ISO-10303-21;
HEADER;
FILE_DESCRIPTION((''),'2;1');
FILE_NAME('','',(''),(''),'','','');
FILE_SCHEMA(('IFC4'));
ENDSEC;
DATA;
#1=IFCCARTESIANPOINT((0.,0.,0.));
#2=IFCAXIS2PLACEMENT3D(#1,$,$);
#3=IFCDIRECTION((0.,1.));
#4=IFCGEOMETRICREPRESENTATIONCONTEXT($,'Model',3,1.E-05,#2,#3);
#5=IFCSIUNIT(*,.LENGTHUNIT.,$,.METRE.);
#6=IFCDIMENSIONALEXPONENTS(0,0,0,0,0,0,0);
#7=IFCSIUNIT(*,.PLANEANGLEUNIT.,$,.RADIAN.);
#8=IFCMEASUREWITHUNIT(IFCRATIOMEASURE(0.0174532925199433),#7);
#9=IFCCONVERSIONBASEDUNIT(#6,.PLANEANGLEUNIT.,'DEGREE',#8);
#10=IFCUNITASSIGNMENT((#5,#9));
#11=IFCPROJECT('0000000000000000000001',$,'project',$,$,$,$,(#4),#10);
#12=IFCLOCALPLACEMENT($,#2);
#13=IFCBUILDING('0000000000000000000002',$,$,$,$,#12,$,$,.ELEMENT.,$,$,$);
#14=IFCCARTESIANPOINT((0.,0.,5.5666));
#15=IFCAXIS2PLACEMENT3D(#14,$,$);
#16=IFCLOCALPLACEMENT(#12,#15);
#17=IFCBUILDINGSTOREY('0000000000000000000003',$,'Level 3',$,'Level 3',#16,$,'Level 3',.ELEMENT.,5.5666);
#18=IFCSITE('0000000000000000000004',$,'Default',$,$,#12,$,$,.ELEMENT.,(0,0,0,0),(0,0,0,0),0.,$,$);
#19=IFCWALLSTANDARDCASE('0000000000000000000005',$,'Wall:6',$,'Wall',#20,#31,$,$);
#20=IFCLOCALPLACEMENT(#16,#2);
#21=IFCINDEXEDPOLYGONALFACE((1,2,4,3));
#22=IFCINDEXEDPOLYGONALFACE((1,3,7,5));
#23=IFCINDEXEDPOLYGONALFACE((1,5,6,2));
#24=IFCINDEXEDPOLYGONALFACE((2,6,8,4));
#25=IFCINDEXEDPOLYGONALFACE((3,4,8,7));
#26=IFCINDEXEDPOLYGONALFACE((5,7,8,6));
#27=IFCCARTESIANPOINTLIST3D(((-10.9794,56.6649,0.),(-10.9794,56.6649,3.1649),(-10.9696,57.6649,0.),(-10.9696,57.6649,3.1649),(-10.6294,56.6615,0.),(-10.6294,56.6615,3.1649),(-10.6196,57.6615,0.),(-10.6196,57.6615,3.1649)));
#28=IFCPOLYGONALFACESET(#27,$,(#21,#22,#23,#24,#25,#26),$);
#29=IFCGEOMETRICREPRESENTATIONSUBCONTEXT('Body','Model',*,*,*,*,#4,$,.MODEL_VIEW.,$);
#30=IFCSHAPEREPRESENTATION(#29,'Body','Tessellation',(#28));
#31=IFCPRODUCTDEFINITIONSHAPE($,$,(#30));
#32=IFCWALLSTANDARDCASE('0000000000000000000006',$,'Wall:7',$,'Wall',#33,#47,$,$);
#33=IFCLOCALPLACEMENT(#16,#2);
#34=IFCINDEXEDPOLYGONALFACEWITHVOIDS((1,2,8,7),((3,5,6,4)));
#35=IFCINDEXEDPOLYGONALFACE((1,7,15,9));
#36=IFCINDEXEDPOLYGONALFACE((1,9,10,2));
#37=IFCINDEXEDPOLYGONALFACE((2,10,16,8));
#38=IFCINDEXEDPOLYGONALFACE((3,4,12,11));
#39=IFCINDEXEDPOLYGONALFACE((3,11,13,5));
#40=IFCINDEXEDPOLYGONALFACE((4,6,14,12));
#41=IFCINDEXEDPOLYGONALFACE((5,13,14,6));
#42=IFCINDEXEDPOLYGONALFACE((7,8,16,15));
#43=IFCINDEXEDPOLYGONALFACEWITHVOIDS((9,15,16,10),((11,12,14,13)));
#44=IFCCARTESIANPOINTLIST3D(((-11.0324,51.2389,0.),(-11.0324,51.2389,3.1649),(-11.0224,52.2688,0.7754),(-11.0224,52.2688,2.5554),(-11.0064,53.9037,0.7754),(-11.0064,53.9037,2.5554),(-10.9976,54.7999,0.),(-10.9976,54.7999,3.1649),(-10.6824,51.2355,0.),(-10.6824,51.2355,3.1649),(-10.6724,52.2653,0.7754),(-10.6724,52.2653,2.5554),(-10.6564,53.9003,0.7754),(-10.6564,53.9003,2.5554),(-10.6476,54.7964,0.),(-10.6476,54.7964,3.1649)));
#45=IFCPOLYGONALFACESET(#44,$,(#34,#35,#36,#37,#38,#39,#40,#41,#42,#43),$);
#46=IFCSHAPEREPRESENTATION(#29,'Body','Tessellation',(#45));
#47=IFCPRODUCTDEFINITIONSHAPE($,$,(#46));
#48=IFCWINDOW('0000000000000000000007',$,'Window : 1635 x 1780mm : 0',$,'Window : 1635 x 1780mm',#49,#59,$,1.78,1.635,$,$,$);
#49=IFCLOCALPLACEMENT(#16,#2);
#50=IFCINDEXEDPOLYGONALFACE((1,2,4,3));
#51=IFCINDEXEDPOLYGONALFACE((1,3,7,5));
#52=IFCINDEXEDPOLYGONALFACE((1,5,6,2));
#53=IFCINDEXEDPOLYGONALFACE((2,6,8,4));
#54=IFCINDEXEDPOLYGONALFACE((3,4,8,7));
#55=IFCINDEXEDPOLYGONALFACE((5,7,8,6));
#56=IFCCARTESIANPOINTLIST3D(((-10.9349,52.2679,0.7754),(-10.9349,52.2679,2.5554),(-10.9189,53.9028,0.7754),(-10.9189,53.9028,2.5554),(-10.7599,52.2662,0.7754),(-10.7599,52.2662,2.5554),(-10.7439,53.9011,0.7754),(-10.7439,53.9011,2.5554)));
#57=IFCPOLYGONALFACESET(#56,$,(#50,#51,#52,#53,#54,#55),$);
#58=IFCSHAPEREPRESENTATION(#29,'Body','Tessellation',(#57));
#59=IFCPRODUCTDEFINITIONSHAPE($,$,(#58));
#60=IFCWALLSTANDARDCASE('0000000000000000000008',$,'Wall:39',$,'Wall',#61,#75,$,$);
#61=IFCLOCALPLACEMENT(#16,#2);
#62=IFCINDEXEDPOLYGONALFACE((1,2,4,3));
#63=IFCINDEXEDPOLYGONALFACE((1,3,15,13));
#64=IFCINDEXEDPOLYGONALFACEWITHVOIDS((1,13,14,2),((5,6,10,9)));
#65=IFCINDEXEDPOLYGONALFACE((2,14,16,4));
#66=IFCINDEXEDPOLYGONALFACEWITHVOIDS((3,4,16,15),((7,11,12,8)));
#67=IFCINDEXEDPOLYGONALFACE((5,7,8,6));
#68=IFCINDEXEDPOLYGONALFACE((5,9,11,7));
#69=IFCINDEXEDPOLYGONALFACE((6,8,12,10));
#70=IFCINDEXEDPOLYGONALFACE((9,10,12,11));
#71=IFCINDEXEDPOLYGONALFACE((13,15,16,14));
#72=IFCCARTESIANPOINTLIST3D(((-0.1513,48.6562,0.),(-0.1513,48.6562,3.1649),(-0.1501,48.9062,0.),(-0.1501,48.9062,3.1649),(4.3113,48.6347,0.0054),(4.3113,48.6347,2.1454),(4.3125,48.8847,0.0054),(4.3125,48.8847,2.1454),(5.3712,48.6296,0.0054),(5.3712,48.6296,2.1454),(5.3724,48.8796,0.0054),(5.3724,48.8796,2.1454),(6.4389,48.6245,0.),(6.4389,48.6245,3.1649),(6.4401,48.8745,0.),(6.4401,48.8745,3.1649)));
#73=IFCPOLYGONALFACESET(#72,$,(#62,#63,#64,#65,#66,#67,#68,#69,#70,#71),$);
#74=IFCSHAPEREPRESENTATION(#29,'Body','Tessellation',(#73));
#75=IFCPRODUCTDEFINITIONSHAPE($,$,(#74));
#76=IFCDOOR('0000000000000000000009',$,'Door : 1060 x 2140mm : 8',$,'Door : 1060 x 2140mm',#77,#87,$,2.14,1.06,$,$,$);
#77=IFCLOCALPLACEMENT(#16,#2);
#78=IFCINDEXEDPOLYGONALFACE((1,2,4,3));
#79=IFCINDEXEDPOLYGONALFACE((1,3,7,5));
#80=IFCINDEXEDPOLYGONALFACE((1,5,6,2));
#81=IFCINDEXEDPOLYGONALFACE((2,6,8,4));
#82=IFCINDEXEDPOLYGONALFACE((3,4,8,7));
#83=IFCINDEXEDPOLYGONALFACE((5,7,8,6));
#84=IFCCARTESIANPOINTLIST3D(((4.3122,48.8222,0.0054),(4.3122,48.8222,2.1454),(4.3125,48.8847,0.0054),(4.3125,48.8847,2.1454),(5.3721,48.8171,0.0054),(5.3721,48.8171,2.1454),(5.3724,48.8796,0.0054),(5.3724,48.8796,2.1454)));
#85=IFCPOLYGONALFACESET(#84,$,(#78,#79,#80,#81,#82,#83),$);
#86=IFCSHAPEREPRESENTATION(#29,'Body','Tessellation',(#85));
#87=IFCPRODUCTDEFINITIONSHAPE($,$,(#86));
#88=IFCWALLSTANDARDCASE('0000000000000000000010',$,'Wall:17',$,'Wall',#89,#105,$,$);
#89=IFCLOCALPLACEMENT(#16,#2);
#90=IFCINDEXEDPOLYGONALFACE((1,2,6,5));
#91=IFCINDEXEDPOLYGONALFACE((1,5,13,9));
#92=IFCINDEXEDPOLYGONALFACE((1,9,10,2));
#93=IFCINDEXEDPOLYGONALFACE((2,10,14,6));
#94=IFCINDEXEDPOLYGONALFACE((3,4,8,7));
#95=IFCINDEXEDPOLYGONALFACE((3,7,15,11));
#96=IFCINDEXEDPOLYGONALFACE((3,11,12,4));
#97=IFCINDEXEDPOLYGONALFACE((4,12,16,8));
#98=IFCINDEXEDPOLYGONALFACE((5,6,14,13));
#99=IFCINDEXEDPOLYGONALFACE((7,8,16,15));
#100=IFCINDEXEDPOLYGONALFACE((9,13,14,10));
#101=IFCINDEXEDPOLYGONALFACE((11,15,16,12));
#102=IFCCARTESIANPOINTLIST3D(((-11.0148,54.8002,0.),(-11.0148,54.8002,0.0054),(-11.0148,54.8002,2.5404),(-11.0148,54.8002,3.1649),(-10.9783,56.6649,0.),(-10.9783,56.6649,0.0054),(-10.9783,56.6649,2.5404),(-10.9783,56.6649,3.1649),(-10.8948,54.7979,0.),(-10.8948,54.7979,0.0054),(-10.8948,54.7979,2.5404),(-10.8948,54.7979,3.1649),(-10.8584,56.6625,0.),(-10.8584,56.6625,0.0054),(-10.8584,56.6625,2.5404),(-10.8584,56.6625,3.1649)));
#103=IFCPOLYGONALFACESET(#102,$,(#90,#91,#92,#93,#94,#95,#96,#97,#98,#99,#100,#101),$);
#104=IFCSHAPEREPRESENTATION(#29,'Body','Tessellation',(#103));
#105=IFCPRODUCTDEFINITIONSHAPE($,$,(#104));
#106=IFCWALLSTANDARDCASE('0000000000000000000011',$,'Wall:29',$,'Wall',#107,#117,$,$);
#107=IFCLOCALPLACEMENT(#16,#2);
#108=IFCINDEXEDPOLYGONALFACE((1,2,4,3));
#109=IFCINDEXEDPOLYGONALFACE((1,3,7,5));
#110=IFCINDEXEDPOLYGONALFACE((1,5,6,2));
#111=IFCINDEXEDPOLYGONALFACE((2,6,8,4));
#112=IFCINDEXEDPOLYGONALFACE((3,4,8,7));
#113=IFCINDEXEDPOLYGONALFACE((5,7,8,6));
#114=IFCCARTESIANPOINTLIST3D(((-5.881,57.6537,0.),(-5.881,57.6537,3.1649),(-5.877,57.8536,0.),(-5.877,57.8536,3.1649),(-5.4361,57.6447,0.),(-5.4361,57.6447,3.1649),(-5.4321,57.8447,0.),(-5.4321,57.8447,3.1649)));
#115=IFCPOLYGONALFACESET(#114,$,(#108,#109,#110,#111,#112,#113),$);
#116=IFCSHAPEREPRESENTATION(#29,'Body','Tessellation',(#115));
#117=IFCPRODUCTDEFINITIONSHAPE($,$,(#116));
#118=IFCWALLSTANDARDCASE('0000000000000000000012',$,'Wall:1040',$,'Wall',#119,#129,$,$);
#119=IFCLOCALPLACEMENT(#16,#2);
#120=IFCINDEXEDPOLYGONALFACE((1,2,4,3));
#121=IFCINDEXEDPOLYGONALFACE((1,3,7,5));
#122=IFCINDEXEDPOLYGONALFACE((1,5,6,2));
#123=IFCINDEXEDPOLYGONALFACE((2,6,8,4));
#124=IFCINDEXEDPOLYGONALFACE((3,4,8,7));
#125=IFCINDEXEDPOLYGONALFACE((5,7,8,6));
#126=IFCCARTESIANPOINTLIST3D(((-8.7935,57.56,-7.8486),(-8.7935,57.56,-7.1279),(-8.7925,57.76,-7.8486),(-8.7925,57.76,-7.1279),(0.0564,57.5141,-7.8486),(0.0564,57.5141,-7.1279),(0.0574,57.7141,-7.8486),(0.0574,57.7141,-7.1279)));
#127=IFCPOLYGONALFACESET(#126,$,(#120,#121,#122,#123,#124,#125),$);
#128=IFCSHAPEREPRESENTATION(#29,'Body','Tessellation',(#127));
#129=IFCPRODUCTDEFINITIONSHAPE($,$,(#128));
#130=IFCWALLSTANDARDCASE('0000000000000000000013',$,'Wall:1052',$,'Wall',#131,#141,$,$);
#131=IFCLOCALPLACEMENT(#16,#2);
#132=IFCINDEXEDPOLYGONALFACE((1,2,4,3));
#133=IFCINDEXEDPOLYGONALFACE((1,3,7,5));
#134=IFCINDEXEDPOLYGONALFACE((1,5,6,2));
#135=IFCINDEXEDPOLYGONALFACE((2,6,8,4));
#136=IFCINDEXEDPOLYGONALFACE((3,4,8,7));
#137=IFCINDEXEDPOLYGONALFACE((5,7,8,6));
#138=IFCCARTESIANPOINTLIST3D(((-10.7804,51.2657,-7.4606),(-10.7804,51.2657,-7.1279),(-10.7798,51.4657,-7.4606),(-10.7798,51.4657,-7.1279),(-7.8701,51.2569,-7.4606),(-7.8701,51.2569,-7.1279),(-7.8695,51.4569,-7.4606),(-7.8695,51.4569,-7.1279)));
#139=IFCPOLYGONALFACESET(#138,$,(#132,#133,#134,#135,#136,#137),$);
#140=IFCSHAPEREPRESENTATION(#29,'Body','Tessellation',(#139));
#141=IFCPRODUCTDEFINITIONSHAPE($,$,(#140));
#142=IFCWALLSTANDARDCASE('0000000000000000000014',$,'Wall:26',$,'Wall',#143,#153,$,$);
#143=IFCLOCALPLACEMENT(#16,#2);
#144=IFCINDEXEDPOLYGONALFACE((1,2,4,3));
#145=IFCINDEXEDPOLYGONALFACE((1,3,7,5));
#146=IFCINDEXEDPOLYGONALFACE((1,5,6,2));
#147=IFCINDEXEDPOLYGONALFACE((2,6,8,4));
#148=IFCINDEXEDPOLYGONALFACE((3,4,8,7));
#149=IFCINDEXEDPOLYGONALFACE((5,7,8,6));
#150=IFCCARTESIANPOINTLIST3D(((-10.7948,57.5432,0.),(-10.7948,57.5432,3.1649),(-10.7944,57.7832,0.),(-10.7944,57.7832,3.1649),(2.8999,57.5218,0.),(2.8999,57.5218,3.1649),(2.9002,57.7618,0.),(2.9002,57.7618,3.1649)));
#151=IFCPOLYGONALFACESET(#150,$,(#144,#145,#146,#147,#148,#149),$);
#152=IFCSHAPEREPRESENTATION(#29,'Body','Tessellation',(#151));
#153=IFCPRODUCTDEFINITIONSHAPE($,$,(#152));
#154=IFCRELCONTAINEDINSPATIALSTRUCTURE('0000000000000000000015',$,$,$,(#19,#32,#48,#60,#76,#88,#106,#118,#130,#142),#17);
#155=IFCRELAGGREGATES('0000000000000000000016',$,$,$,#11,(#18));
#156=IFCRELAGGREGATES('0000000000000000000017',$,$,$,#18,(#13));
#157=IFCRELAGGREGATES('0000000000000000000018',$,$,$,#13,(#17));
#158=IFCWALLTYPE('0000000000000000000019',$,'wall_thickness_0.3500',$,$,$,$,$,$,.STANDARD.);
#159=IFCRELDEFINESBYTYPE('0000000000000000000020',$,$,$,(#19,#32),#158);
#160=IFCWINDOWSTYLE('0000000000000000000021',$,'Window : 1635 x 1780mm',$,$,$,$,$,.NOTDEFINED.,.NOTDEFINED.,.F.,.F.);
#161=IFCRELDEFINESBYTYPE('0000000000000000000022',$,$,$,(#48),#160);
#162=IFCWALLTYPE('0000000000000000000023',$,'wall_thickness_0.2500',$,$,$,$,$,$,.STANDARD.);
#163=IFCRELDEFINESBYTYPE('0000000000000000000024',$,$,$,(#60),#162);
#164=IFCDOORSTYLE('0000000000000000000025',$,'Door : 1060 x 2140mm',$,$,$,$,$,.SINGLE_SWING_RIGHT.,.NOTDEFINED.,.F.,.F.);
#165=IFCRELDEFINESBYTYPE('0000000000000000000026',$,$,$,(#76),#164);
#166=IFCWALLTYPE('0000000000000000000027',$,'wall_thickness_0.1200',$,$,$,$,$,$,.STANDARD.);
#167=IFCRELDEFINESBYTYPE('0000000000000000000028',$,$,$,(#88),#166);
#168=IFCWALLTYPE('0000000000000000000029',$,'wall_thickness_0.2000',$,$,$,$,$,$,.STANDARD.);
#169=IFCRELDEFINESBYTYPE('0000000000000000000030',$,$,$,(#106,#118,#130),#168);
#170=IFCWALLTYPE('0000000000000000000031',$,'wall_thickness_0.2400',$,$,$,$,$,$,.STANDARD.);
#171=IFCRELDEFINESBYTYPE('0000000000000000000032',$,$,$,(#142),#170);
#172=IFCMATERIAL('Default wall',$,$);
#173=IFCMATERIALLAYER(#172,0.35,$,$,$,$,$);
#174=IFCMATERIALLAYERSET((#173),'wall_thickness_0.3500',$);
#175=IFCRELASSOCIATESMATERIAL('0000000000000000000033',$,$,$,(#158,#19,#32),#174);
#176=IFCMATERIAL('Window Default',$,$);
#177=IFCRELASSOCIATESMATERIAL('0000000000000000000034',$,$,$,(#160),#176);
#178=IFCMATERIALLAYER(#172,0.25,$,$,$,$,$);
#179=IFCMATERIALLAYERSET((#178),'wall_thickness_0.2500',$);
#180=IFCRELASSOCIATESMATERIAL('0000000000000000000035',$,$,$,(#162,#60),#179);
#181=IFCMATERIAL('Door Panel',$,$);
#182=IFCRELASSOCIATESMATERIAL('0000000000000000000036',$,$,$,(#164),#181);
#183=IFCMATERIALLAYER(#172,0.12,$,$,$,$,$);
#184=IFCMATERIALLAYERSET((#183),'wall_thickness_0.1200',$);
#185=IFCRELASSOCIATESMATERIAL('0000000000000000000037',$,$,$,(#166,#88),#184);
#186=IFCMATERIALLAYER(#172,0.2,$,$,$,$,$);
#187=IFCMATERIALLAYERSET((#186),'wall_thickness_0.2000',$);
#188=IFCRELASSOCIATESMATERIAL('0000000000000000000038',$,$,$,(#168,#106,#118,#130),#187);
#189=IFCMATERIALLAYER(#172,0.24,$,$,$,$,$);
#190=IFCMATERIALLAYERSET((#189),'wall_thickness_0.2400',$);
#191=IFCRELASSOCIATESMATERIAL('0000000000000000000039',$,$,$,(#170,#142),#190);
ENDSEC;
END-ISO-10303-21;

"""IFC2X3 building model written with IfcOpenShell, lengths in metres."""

from ifc_helpers import new_model, entity, si_unit, converted_unit, direction, frame, frame_2d, origin, origin_2d_with_axis, place, context, subcontext, project, spatial, polyline, rectangle, outline, extrude, source, transform, mapped, material, layer, layer_set, layer_usage, type_object, type_shapes, element, fill, save


model = new_model("IFC2X3")

# Units and contexts
model_context = context("Model", 3, precision=1e-05, world=origin(), true_north=direction((0.0, 1.0)))
body_context = subcontext(model_context, "Body", "Model", "MODEL_VIEW")
ifc_project = project(units=[si_unit("LENGTHUNIT", "METRE"), converted_unit("PLANEANGLEUNIT", "DEGREE", entity("IfcRatioMeasure", 0.0174532925199433), si_unit("PLANEANGLEUNIT", "RADIAN"), dimensions=[0, 0, 0, 0, 0, 0, 0])], contexts=[model_context])

# Site, building, storey
placement_1 = place(None, origin())
site = spatial("IfcSite", under=ifc_project, at=placement_1, Name="Default", CompositionType="ELEMENT", RefLatitude=(0, 0, 0, 0), RefLongitude=(0, 0, 0, 0), RefElevation=0.0)
building = spatial("IfcBuilding", under=site, at=placement_1, CompositionType="ELEMENT")
storey_placement = place(placement_1, frame((0.0, 0.0, 5.5666)))
storey = spatial("IfcBuildingStorey", under=building, at=storey_placement, Name="Level 3", ObjectType="Level 3", LongName="Level 3", CompositionType="ELEMENT", Elevation=5.5666)

# Wall
ifc_material_1 = material(Name="Default wall")
ifc_layer_1 = layer(ifc_material_1, 0.35)
ifc_layer_set_1 = layer_set([ifc_layer_1], Name="wall_thickness_0.3500")
ifc_layer_usage_1 = layer_usage(ifc_layer_set_1, "AXIS2", "POSITIVE", -0.175)
wall_type_1 = type_object("IfcWallType", Name="wall_thickness_0.3500", PredefinedType="STANDARD", material=ifc_layer_set_1)
wall_1_placement = place(storey_placement, frame((-10.7946, 57.6632, 0.0), z_axis=(0.0, 0.0, 1.0), x_axis=(-0.009774, -0.999952, 0.0)))
element("IfcWallStandardCase", 1, at=wall_1_placement, inside=storey, type_object=wall_type_1, material=ifc_layer_usage_1, Name="Wall:6", ObjectType="Wall", context=body_context, shape_type="SweptSolid", body=[
    extrude(outline(polyline([(1.0001, -0.175), (1.0001, 0.175), (0.0, 0.175), (0.0, -0.175), (1.0001, -0.175)])), origin(), (0.0, 0.0, 1.0), 3.1649),
])

# Wall, opening, window
wall_2_placement = place(storey_placement, frame((-10.8226, 54.7982, 0.0), z_axis=(0.0, 0.0, 1.0), x_axis=(-0.009774, -0.999952, 0.0)))
wall_2 = element("IfcWallStandardCase", 2, at=wall_2_placement, inside=storey, type_object=wall_type_1, material=ifc_layer_usage_1, Name="Wall:7", ObjectType="Wall", context=body_context, shape_type="SweptSolid", body=[
    extrude(outline(polyline([(3.5612, -0.175), (3.5612, 0.175), (0.0, 0.175), (0.0, -0.175), (3.5612, -0.175)])), origin(), (0.0, 0.0, 1.0), 3.1649),
])
opening_1_placement = place(wall_2_placement, frame((0.8962, -0.175, 0.7754)))
opening_1 = element("IfcOpeningElement", 3, at=opening_1_placement, cuts=wall_2, ObjectType="Opening", context=body_context, shape_type="SweptSolid", body=[
    extrude(rectangle(XDim=1.635, YDim=1.78, at=frame_2d((0.89, 0.8175), x_axis=(0.0, 1.0))), frame((0.0, 0.0, 0.0), z_axis=(0.0, 1.0, 0.0), x_axis=(0.0, 0.0, 1.0)), (0.0, 0.0, 1.0), 0.35),
])
ifc_material_2 = material(Name="Window Default")
window_style_1 = type_object("IfcWindowStyle", Name="Window : 1635 x 1780mm", ConstructionType="NOTDEFINED", OperationType="NOTDEFINED", ParameterTakesPrecedence=False, Sizeable=False, material=ifc_material_2)
shared_shape_1 = source(origin(), body_context, "Body", "SweptSolid", [
    extrude(rectangle(XDim=0.175, YDim=1.635, at=origin_2d_with_axis()), frame((0.8175, 0.175, 0.0), z_axis=(0.0, 0.0, 1.0), x_axis=(0.0, 1.0, 0.0)), (0.0, 0.0, 1.0), 1.78),
])
type_shapes(window_style_1, [shared_shape_1])
window_1_placement = place(opening_1_placement, origin())
window_1 = element("IfcWindow", 4, at=window_1_placement, inside=storey, type_object=window_style_1, Name="Window : 1635 x 1780mm : 0", ObjectType="Window : 1635 x 1780mm", OverallHeight=1.78, OverallWidth=1.635, context=body_context, shape_type="MappedRepresentation", body=[
    mapped(shared_shape_1, transform((0.0, 0.0, 0.0), scale=1.0)),
])
fill(opening_1, window_1)

# Wall, opening, door
ifc_layer_2 = layer(ifc_material_1, 0.25)
ifc_layer_set_2 = layer_set([ifc_layer_2], Name="wall_thickness_0.2500")
ifc_layer_usage_2 = layer_usage(ifc_layer_set_2, "AXIS2", "POSITIVE", -0.125)
wall_type_2 = type_object("IfcWallType", Name="wall_thickness_0.2500", PredefinedType="STANDARD", material=ifc_layer_set_2)
wall_3_placement = place(storey_placement, frame((-0.1507, 48.7812, 0.0), z_axis=(0.0, 0.0, 1.0), x_axis=(0.999988, -0.004812, 0.0)))
wall_3 = element("IfcWallStandardCase", 5, at=wall_3_placement, inside=storey, type_object=wall_type_2, material=ifc_layer_usage_2, Name="Wall:39", ObjectType="Wall", context=body_context, shape_type="SweptSolid", body=[
    extrude(outline(polyline([(6.5902, -0.125), (6.5902, 0.125), (0.0, 0.125), (0.0, -0.125), (6.5902, -0.125)])), origin(), (0.0, 0.0, 1.0), 3.1649),
])
opening_2_placement = place(wall_3_placement, frame((4.4626, -0.125, 0.0054)))
opening_2 = element("IfcOpeningElement", 6, at=opening_2_placement, cuts=wall_3, ObjectType="Opening", context=body_context, shape_type="SweptSolid", body=[
    extrude(rectangle(XDim=1.06, YDim=2.14, at=frame_2d((1.07, 0.53), x_axis=(0.0, 1.0))), frame((0.0, 0.0, 0.0), z_axis=(0.0, 1.0, 0.0), x_axis=(0.0, 0.0, 1.0)), (0.0, 0.0, 1.0), 0.25),
])
ifc_material_3 = material(Name="Door Panel")
door_style = type_object("IfcDoorStyle", Name="Door : 1060 x 2140mm", ConstructionType="NOTDEFINED", OperationType="SINGLE_SWING_RIGHT", ParameterTakesPrecedence=False, Sizeable=False, material=ifc_material_3)
shared_shape_2 = source(origin(), body_context, "Body", "SweptSolid", [
    extrude(rectangle(XDim=0.0625, YDim=1.06, at=origin_2d_with_axis()), frame((0.53, 0.2188, 0.0), z_axis=(0.0, 0.0, 1.0), x_axis=(0.0, 1.0, 0.0)), (0.0, 0.0, 1.0), 2.14),
])
type_shapes(door_style, [shared_shape_2])
door_placement = place(opening_2_placement, origin())
door = element("IfcDoor", 7, at=door_placement, inside=storey, type_object=door_style, Name="Door : 1060 x 2140mm : 8", ObjectType="Door : 1060 x 2140mm", OverallHeight=2.14, OverallWidth=1.06, context=body_context, shape_type="MappedRepresentation", body=[
    mapped(shared_shape_2, transform((0.0, 0.0, 0.0), scale=1.0)),
])
fill(opening_2, door)

# Wall, opening
ifc_layer_3 = layer(ifc_material_1, 0.12)
ifc_layer_set_3 = layer_set([ifc_layer_3], Name="wall_thickness_0.1200")
ifc_layer_usage_3 = layer_usage(ifc_layer_set_3, "AXIS2", "POSITIVE", -0.06)
wall_type_3 = type_object("IfcWallType", Name="wall_thickness_0.1200", PredefinedType="STANDARD", material=ifc_layer_set_3)
wall_4_placement = place(storey_placement, frame((-10.9184, 56.6637, 0.0), z_axis=(0.0, 0.0, 1.0), x_axis=(-0.019539, -0.999809, 0.0)))
wall_4 = element("IfcWallStandardCase", 8, at=wall_4_placement, inside=storey, type_object=wall_type_3, material=ifc_layer_usage_3, Name="Wall:17", ObjectType="Wall", context=body_context, shape_type="SweptSolid", body=[
    extrude(outline(polyline([(1.865, -0.06), (1.865, 0.06), (0.0, 0.06), (0.0, -0.06), (1.865, -0.06)])), origin(), (0.0, 0.0, 1.0), 3.1649),
])
opening_3_placement = place(wall_4_placement, frame((-0.1187, -0.06, 0.0054)))
element("IfcOpeningElement", 9, at=opening_3_placement, cuts=wall_4, ObjectType="Opening", context=body_context, shape_type="SweptSolid", body=[
    extrude(rectangle(XDim=2.0, YDim=2.535, at=frame_2d((1.2675, 1.0), x_axis=(0.0, 1.0))), frame((0.0, 0.0, 0.0), z_axis=(0.0, 1.0, 0.0), x_axis=(0.0, 0.0, 1.0)), (0.0, 0.0, 1.0), 0.12),
])

# Walls
ifc_layer_4 = layer(ifc_material_1, 0.2)
ifc_layer_set_4 = layer_set([ifc_layer_4], Name="wall_thickness_0.2000")
ifc_layer_usage_4 = layer_usage(ifc_layer_set_4, "AXIS2", "POSITIVE", -0.1)
wall_type_4 = type_object("IfcWallType", Name="wall_thickness_0.2000", PredefinedType="STANDARD", material=ifc_layer_set_4)
wall_5_placement = place(storey_placement, frame((-5.879, 57.7537, 0.0), z_axis=(0.0, 0.0, 1.0), x_axis=(0.999797, -0.020128, 0.0)))
element("IfcWallStandardCase", 10, at=wall_5_placement, inside=storey, type_object=wall_type_4, material=ifc_layer_usage_4, Name="Wall:29", ObjectType="Wall", context=body_context, shape_type="SweptSolid", body=[
    extrude(outline(polyline([(0.445, -0.1), (0.445, 0.1), (0.0, 0.1), (0.0, -0.1), (0.445, -0.1)])), origin(), (0.0, 0.0, 1.0), 3.1649),
])
placement_2 = place(placement_1, frame((0.0, 0.0, -2.282)))
wall_6_placement = place(placement_2, frame((-8.793, 57.66, 0.0), z_axis=(0.0, 0.0, 1.0), x_axis=(0.999987, -0.005185, 0.0)))
element("IfcWallStandardCase", 11, at=wall_6_placement, inside=storey, type_object=wall_type_4, material=ifc_layer_usage_4, Name="Wall:1040", ObjectType="Wall", context=body_context, shape_type="SweptSolid", body=[
    extrude(outline(polyline([(8.85, -0.1), (8.85, 0.1), (0.0, 0.1), (0.0, -0.1), (8.85, -0.1)])), origin(), (0.0, 0.0, 1.0), 0.7207),
])
placement_3 = place(placement_1, frame((0.0, 0.0, -1.894)))
wall_7_placement = place(placement_3, frame((-10.7801, 51.3657, 0.0), z_axis=(0.0, 0.0, 1.0), x_axis=(0.999995, -0.003006, 0.0)))
element("IfcWallStandardCase", 12, at=wall_7_placement, inside=storey, type_object=wall_type_4, material=ifc_layer_usage_4, Name="Wall:1052", ObjectType="Wall", context=body_context, shape_type="SweptSolid", body=[
    extrude(outline(polyline([(2.9103, -0.1), (2.9103, 0.1), (0.0, 0.1), (0.0, -0.1), (2.9103, -0.1)])), origin(), (0.0, 0.0, 1.0), 0.3327),
])
ifc_layer_5 = layer(ifc_material_1, 0.24)
ifc_layer_set_5 = layer_set([ifc_layer_5], Name="wall_thickness_0.2400")
ifc_layer_usage_5 = layer_usage(ifc_layer_set_5, "AXIS2", "POSITIVE", -0.12)
wall_type_5 = type_object("IfcWallType", Name="wall_thickness_0.2400", PredefinedType="STANDARD", material=ifc_layer_set_5)
wall_8_placement = place(storey_placement, frame((-10.7946, 57.6632, 0.0), z_axis=(0.0, 0.0, 1.0), x_axis=(0.999999, -0.001565, 0.0)))
element("IfcWallStandardCase", 13, at=wall_8_placement, inside=storey, type_object=wall_type_5, material=ifc_layer_usage_5, Name="Wall:26", ObjectType="Wall", context=body_context, shape_type="SweptSolid", body=[
    extrude(outline(polyline([(13.6947, -0.12), (13.6947, 0.12), (0.0, 0.12), (0.0, -0.12), (13.6947, -0.12)])), origin(), (0.0, 0.0, 1.0), 3.1649),
])

save(model, "model.ifc")
